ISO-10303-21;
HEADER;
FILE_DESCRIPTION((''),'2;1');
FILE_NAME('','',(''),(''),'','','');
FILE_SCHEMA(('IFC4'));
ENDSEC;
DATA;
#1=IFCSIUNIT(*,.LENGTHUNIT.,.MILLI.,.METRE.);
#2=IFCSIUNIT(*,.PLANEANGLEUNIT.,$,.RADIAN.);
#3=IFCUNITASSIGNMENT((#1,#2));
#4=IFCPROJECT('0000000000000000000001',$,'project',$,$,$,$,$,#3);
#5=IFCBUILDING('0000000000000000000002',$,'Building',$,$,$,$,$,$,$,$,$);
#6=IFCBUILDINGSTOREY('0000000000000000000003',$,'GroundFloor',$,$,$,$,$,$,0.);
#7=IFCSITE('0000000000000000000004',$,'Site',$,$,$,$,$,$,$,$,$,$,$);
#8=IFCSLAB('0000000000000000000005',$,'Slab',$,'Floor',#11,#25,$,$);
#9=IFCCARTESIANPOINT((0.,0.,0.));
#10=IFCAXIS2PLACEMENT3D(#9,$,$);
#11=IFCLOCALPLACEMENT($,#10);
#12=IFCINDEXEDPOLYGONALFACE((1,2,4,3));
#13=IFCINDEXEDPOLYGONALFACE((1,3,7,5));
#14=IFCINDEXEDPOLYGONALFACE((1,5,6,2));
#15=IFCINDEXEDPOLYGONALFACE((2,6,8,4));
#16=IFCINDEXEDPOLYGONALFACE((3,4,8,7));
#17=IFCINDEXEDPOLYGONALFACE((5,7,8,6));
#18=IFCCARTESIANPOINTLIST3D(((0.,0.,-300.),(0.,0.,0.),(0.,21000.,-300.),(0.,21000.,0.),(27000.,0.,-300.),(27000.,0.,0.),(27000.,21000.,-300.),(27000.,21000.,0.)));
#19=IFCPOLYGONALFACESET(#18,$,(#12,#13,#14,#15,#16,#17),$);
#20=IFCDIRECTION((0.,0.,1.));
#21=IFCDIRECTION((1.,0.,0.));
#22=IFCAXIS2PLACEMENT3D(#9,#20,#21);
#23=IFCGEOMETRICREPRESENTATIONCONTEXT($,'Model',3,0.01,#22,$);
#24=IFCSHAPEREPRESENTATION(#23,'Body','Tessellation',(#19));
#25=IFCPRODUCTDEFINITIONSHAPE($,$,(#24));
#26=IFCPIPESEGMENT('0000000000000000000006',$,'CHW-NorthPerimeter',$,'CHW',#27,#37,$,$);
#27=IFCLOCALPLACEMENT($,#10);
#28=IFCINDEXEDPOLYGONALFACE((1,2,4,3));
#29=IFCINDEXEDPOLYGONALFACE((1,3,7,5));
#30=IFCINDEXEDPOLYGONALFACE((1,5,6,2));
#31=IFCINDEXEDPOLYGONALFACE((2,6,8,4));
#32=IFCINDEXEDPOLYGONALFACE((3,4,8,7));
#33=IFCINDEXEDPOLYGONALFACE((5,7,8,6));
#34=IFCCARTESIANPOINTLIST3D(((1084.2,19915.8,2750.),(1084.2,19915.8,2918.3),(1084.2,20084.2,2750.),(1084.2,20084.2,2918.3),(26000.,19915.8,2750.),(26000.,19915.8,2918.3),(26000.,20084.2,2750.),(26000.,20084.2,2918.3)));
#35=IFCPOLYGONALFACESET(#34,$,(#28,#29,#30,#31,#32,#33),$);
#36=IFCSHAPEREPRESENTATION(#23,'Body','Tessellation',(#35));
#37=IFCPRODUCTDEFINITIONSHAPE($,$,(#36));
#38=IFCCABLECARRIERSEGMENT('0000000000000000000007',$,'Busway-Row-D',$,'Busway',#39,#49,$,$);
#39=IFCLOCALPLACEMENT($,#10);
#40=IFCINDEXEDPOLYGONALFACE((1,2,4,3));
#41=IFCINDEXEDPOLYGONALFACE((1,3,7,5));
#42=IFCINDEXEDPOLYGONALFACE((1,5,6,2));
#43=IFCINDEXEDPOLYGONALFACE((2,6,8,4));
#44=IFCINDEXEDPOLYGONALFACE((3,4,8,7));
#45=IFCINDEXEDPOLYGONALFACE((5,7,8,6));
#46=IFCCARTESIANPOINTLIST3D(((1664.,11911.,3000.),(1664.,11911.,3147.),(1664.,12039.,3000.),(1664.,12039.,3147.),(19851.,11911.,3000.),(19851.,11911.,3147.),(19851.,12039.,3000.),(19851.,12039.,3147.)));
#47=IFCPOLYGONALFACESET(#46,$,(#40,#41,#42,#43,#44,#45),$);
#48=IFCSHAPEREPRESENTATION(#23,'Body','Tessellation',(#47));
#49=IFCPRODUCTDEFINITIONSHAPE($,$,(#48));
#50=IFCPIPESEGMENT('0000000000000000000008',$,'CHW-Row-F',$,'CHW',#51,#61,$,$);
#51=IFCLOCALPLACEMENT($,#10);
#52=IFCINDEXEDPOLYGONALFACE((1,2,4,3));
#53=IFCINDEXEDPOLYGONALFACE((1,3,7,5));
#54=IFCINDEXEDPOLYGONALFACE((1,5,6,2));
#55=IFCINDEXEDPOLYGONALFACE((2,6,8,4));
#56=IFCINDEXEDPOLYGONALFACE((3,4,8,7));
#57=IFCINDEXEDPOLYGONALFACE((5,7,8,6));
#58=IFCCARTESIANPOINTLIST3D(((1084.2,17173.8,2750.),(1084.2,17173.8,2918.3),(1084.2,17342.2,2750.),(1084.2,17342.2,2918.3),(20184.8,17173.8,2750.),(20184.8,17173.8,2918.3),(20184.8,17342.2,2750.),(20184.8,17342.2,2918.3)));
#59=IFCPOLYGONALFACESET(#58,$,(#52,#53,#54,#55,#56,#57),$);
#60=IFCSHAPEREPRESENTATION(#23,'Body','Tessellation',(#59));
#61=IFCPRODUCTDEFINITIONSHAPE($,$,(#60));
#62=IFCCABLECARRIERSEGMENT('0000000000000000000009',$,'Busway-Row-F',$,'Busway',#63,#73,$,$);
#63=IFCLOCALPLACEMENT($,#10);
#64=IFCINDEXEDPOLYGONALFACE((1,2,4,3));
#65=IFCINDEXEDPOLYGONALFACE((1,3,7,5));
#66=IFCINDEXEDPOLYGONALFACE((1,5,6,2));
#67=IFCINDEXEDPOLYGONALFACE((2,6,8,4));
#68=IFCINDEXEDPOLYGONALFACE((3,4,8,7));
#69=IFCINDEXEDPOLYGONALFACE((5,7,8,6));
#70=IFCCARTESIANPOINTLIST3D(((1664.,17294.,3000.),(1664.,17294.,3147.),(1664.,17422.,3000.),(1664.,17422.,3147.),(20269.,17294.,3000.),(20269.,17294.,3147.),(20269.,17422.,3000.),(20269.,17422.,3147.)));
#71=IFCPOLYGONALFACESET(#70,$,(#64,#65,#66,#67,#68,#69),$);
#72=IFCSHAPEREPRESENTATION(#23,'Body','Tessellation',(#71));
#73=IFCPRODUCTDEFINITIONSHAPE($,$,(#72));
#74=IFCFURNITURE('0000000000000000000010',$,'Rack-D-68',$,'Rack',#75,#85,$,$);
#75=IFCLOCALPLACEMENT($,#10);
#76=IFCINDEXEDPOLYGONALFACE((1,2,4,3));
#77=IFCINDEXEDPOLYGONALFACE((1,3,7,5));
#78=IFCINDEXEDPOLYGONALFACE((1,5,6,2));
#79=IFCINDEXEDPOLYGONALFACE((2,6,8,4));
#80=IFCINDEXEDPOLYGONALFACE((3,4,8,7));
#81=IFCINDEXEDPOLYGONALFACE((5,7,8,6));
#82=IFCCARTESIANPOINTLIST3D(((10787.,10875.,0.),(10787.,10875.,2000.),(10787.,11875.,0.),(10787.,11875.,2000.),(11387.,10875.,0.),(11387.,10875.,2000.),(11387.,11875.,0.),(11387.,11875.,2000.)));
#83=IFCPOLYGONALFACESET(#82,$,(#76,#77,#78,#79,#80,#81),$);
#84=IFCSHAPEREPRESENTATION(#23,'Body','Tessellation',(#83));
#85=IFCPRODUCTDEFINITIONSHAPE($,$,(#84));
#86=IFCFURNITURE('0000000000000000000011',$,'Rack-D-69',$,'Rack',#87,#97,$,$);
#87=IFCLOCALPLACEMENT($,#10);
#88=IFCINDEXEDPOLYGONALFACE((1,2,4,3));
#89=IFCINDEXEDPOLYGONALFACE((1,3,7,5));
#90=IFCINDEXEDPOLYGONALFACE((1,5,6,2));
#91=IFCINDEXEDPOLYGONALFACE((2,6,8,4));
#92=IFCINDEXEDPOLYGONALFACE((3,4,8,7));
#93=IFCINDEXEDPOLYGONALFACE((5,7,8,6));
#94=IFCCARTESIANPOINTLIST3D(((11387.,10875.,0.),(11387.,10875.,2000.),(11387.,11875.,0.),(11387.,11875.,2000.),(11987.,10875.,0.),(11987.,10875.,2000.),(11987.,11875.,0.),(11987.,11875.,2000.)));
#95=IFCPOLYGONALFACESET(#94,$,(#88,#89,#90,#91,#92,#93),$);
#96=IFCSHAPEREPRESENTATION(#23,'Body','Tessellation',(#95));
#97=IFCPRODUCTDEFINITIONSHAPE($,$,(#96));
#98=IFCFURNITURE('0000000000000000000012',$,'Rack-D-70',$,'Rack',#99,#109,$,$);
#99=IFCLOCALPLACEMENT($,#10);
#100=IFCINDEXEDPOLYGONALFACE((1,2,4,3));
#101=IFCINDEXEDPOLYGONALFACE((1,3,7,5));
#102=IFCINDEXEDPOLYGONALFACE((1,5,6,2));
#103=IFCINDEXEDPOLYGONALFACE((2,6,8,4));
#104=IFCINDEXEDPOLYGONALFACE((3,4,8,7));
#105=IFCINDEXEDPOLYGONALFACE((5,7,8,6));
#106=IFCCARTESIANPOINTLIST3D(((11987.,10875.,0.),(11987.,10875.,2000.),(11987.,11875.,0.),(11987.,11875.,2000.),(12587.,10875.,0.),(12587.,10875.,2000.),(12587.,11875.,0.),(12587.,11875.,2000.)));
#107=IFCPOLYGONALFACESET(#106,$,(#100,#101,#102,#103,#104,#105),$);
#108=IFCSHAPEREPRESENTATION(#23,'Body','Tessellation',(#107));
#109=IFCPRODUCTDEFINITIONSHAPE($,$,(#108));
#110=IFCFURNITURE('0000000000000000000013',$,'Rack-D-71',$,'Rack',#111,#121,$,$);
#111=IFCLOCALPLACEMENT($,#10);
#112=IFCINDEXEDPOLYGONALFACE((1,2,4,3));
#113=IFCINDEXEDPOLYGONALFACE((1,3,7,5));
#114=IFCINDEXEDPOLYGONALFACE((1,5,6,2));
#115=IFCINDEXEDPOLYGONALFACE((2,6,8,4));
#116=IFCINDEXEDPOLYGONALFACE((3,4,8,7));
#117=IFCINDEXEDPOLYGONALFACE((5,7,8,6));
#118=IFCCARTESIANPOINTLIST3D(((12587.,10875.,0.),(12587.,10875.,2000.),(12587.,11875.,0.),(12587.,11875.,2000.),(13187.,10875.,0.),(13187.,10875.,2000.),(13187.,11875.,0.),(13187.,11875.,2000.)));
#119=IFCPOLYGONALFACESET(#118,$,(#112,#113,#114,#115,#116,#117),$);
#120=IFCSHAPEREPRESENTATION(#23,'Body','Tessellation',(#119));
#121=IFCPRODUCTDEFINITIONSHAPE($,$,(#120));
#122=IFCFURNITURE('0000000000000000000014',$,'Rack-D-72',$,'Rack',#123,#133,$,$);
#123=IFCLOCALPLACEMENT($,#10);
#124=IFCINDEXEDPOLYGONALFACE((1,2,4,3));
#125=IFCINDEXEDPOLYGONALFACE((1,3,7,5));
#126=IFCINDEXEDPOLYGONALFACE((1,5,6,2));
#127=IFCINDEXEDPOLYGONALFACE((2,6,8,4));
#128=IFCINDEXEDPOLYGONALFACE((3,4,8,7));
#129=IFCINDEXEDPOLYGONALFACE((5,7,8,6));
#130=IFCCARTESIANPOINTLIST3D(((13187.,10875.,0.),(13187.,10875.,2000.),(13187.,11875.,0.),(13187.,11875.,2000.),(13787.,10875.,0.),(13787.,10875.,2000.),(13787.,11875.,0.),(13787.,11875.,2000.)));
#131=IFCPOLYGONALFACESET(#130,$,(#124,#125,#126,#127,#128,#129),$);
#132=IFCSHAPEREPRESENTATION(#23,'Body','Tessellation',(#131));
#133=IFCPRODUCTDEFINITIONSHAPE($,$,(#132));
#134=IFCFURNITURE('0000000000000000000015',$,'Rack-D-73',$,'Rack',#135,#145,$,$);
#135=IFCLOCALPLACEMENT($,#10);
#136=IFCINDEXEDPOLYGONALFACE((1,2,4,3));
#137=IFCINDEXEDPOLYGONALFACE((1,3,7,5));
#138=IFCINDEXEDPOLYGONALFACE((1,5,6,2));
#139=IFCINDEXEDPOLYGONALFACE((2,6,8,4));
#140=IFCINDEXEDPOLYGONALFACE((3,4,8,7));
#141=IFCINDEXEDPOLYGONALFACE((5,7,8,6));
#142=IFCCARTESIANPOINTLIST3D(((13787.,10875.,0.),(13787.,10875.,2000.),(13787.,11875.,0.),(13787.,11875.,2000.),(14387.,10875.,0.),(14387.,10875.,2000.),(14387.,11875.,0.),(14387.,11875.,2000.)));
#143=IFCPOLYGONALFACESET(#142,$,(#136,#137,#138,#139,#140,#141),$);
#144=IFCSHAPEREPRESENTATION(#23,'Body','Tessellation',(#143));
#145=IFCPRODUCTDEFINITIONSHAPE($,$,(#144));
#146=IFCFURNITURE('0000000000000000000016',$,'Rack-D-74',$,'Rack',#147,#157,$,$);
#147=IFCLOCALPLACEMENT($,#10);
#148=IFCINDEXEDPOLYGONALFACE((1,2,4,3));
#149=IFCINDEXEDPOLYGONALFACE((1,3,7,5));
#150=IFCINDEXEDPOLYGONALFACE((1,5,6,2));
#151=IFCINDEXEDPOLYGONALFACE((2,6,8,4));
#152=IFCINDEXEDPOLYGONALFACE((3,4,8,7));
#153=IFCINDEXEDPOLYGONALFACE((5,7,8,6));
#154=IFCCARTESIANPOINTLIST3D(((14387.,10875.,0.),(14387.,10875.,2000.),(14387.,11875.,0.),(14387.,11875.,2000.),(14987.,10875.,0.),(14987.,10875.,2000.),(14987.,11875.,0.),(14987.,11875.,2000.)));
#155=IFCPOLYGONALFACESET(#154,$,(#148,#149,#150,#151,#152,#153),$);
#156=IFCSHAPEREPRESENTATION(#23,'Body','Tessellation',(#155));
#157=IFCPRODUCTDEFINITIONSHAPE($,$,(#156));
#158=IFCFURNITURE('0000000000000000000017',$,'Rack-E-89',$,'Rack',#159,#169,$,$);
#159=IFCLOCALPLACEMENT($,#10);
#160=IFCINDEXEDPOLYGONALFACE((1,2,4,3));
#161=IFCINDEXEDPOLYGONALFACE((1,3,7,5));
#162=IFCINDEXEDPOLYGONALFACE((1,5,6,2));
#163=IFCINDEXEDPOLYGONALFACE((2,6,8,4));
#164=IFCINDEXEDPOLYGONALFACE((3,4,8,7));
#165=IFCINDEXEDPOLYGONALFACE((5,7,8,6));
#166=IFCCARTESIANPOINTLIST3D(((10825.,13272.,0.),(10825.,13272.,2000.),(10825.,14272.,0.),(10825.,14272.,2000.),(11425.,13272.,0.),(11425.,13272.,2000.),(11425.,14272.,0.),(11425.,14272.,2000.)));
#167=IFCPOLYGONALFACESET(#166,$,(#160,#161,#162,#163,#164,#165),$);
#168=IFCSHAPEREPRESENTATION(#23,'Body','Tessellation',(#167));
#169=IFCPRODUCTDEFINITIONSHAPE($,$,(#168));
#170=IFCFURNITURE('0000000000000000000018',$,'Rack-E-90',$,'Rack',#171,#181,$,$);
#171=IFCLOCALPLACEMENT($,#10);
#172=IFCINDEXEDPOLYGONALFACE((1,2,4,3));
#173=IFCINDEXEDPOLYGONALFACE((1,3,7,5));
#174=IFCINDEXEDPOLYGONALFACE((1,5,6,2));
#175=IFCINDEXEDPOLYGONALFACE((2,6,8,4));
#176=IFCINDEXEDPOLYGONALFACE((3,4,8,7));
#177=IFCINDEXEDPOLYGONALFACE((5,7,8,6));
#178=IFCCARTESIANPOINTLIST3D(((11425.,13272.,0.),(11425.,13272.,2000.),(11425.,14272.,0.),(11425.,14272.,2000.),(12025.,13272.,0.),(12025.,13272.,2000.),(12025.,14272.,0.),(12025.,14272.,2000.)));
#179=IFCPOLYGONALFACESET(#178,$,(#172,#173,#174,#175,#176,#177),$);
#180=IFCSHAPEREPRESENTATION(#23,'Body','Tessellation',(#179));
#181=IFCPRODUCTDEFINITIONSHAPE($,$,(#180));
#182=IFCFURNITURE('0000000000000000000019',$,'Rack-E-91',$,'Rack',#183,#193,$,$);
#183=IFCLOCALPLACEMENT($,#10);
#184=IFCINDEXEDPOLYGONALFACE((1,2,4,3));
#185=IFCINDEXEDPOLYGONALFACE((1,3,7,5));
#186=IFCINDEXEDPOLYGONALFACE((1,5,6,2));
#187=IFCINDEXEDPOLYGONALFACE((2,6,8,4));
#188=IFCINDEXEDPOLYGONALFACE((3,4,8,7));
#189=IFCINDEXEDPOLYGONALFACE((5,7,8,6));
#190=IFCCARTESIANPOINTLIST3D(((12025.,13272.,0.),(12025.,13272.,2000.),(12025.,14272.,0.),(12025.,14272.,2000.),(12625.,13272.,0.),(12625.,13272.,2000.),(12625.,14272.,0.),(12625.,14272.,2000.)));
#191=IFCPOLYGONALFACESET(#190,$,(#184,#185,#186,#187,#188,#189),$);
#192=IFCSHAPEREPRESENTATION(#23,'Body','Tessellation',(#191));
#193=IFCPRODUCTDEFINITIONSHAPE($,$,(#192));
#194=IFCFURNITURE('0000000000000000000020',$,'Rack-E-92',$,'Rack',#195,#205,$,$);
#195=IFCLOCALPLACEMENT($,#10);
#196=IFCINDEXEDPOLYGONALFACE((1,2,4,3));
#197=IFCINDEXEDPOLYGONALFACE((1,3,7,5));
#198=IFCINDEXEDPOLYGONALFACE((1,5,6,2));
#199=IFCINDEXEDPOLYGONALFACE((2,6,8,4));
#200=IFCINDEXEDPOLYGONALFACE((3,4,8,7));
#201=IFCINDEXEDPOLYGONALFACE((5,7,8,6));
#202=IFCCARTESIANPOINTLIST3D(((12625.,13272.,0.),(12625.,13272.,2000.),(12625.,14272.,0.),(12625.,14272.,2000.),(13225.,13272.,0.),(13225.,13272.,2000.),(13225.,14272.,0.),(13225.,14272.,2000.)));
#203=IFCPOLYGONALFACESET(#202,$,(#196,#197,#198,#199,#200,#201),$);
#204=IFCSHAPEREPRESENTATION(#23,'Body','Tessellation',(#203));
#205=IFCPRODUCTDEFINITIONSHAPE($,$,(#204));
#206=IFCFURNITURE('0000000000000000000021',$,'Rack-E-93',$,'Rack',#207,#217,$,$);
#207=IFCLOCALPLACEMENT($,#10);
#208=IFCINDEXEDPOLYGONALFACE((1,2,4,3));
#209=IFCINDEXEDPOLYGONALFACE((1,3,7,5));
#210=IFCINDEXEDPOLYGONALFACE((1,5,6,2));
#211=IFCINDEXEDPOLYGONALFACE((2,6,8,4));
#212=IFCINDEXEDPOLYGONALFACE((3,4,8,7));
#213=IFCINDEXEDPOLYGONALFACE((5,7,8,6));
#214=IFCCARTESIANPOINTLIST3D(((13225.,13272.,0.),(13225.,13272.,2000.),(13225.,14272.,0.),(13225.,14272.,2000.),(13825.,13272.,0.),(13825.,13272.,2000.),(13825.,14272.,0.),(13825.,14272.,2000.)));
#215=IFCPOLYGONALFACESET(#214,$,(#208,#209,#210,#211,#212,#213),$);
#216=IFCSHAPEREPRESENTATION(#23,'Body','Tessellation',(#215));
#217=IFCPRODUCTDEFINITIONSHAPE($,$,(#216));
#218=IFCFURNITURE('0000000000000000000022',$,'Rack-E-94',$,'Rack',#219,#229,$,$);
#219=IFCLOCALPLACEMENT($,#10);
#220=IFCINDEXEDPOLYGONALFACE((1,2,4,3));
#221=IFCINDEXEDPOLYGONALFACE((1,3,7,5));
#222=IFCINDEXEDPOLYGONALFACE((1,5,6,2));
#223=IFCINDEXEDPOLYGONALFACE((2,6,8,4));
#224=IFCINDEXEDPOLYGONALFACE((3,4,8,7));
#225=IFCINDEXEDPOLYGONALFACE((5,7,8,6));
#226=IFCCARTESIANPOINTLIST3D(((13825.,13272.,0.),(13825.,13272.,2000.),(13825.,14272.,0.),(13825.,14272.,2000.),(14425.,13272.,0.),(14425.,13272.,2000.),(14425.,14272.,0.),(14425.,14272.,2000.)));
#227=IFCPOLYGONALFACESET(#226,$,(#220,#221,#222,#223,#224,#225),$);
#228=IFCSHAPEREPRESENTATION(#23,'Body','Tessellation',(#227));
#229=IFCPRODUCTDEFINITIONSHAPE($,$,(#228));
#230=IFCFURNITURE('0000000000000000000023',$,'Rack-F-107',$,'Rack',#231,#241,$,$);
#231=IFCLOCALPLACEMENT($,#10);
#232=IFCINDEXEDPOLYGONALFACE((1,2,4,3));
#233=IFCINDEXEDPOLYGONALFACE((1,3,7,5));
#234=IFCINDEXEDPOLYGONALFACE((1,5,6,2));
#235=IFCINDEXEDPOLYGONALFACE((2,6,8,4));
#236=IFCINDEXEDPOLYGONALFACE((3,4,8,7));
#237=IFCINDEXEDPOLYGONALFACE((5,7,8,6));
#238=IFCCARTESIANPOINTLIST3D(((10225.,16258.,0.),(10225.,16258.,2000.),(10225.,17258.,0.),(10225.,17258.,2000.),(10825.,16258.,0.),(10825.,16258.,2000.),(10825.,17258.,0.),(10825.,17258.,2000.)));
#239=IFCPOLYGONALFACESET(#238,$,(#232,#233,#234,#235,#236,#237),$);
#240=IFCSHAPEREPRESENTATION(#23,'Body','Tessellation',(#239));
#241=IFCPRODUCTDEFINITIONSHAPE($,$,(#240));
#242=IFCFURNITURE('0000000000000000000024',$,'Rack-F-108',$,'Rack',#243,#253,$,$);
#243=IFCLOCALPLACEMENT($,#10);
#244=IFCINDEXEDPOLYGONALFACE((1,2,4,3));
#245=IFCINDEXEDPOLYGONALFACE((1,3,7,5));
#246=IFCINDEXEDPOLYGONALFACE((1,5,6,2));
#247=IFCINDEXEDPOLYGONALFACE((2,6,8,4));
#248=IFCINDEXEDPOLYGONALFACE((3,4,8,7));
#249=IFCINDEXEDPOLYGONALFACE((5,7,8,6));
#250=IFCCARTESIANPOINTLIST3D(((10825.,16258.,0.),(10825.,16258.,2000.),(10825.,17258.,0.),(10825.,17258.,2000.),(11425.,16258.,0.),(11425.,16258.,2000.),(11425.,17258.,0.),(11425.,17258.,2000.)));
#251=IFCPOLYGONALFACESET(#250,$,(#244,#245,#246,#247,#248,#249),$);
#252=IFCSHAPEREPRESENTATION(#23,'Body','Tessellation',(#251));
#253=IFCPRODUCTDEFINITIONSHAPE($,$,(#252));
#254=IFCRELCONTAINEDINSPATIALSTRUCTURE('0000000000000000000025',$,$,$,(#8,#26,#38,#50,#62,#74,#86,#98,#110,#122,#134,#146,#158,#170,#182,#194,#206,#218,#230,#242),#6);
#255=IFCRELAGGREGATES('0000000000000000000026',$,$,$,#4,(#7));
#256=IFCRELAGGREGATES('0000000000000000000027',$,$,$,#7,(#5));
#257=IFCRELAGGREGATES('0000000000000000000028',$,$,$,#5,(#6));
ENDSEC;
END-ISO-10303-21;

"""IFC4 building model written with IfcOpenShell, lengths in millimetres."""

from ifc_helpers import new_model, si_unit, frame, origin, origin_with_axes, origin_2d, place, context, project, spatial, rectangle, extrude, element, save


model = new_model("IFC4")

# Units and contexts
model_context = context("Model", 3, precision=0.01, world=origin_with_axes())
ifc_project = project(units=[si_unit("LENGTHUNIT", "METRE", prefix="MILLI"), si_unit("PLANEANGLEUNIT", "RADIAN")])

# Site, building, storey
site = spatial("IfcSite", under=ifc_project, Name="Site")
building = spatial("IfcBuilding", under=site, Name="Building")
storey = spatial("IfcBuildingStorey", under=building, Name="GroundFloor", Elevation=0.0)

# Slab
slab_placement = place(None, frame((13500.0, 10500.0, -300.0), z_axis=(0.0, 0.0, 1.0), x_axis=(1.0, 0.0, 0.0)))
element("IfcSlab", 1, at=slab_placement, inside=storey, Name="Slab", ObjectType="Floor", context=model_context, shape_type="SweptSolid", body=[
    extrude(rectangle(XDim=27000.0, YDim=21000.0, at=origin_2d()), origin(), (0.0, 0.0, 1.0), 300.0),
])

# Pipe segment
pipe_segment_1_placement = place(None, frame((13542.1, 20000.0, 2750.0), z_axis=(0.0, 0.0, 1.0), x_axis=(1.0, 0.0, 0.0)))
element("IfcPipeSegment", 2, at=pipe_segment_1_placement, inside=storey, Name="CHW-NorthPerimeter", ObjectType="CHW", context=model_context, shape_type="SweptSolid", body=[
    extrude(rectangle(XDim=24915.8, YDim=168.3, at=origin_2d()), origin(), (0.0, 0.0, 1.0), 168.3),
])

# Cable carrier segment
cable_carrier_segment_1_placement = place(None, frame((10757.5, 11975.0, 3000.0), z_axis=(0.0, 0.0, 1.0), x_axis=(1.0, 0.0, 0.0)))
element("IfcCableCarrierSegment", 3, at=cable_carrier_segment_1_placement, inside=storey, Name="Busway-Row-D", ObjectType="Busway", context=model_context, shape_type="SweptSolid", body=[
    extrude(rectangle(XDim=18187.0, YDim=128.0, at=origin_2d()), origin(), (0.0, 0.0, 1.0), 147.0),
])

# Pipe segment
pipe_segment_2_placement = place(None, frame((10634.5, 17258.0, 2750.0), z_axis=(0.0, 0.0, 1.0), x_axis=(1.0, 0.0, 0.0)))
element("IfcPipeSegment", 4, at=pipe_segment_2_placement, inside=storey, Name="CHW-Row-F", ObjectType="CHW", context=model_context, shape_type="SweptSolid", body=[
    extrude(rectangle(XDim=19100.7, YDim=168.3, at=origin_2d()), origin(), (0.0, 0.0, 1.0), 168.3),
])

# Cable carrier segment
cable_carrier_segment_2_placement = place(None, frame((10966.5, 17358.0, 3000.0), z_axis=(0.0, 0.0, 1.0), x_axis=(1.0, 0.0, 0.0)))
element("IfcCableCarrierSegment", 5, at=cable_carrier_segment_2_placement, inside=storey, Name="Busway-Row-F", ObjectType="Busway", context=model_context, shape_type="SweptSolid", body=[
    extrude(rectangle(XDim=18605.0, YDim=128.0, at=origin_2d()), origin(), (0.0, 0.0, 1.0), 147.0),
])

# Furniture
for number, where, z_axis, x_axis, name in (
    (6, (11087.0, 11375.0, 0.0), (0.0, 0.0, 1.0), (1.0, 0.0, 0.0), "Rack-D-68"),
    (7, (11687.0, 11375.0, 0.0), (0.0, 0.0, 1.0), (1.0, 0.0, 0.0), "Rack-D-69"),
    (8, (12287.0, 11375.0, 0.0), (0.0, 0.0, 1.0), (1.0, 0.0, 0.0), "Rack-D-70"),
    (9, (12887.0, 11375.0, 0.0), (0.0, 0.0, 1.0), (1.0, 0.0, 0.0), "Rack-D-71"),
    (10, (13487.0, 11375.0, 0.0), (0.0, 0.0, 1.0), (1.0, 0.0, 0.0), "Rack-D-72"),
    (11, (14087.0, 11375.0, 0.0), (0.0, 0.0, 1.0), (1.0, 0.0, 0.0), "Rack-D-73"),
    (12, (14687.0, 11375.0, 0.0), (0.0, 0.0, 1.0), (1.0, 0.0, 0.0), "Rack-D-74"),
    (13, (11125.0, 13772.0, 0.0), (0.0, 0.0, 1.0), (1.0, 0.0, 0.0), "Rack-E-89"),
    (14, (11725.0, 13772.0, 0.0), (0.0, 0.0, 1.0), (1.0, 0.0, 0.0), "Rack-E-90"),
    (15, (12325.0, 13772.0, 0.0), (0.0, 0.0, 1.0), (1.0, 0.0, 0.0), "Rack-E-91"),
    (16, (12925.0, 13772.0, 0.0), (0.0, 0.0, 1.0), (1.0, 0.0, 0.0), "Rack-E-92"),
    (17, (13525.0, 13772.0, 0.0), (0.0, 0.0, 1.0), (1.0, 0.0, 0.0), "Rack-E-93"),
    (18, (14125.0, 13772.0, 0.0), (0.0, 0.0, 1.0), (1.0, 0.0, 0.0), "Rack-E-94"),
    (19, (10525.0, 16758.0, 0.0), (0.0, 0.0, 1.0), (1.0, 0.0, 0.0), "Rack-F-107"),
    (20, (11125.0, 16758.0, 0.0), (0.0, 0.0, 1.0), (1.0, 0.0, 0.0), "Rack-F-108"),
):
    element("IfcFurniture", number, at=place(None, frame(where, z_axis=z_axis, x_axis=x_axis)), inside=storey, Name=name, ObjectType="Rack", context=model_context, shape_type="SweptSolid", body=[
        extrude(rectangle(XDim=600.0, YDim=1000.0, at=origin_2d()), origin(), (0.0, 0.0, 1.0), 2000.0),
    ])

save(model, "model.ifc")
